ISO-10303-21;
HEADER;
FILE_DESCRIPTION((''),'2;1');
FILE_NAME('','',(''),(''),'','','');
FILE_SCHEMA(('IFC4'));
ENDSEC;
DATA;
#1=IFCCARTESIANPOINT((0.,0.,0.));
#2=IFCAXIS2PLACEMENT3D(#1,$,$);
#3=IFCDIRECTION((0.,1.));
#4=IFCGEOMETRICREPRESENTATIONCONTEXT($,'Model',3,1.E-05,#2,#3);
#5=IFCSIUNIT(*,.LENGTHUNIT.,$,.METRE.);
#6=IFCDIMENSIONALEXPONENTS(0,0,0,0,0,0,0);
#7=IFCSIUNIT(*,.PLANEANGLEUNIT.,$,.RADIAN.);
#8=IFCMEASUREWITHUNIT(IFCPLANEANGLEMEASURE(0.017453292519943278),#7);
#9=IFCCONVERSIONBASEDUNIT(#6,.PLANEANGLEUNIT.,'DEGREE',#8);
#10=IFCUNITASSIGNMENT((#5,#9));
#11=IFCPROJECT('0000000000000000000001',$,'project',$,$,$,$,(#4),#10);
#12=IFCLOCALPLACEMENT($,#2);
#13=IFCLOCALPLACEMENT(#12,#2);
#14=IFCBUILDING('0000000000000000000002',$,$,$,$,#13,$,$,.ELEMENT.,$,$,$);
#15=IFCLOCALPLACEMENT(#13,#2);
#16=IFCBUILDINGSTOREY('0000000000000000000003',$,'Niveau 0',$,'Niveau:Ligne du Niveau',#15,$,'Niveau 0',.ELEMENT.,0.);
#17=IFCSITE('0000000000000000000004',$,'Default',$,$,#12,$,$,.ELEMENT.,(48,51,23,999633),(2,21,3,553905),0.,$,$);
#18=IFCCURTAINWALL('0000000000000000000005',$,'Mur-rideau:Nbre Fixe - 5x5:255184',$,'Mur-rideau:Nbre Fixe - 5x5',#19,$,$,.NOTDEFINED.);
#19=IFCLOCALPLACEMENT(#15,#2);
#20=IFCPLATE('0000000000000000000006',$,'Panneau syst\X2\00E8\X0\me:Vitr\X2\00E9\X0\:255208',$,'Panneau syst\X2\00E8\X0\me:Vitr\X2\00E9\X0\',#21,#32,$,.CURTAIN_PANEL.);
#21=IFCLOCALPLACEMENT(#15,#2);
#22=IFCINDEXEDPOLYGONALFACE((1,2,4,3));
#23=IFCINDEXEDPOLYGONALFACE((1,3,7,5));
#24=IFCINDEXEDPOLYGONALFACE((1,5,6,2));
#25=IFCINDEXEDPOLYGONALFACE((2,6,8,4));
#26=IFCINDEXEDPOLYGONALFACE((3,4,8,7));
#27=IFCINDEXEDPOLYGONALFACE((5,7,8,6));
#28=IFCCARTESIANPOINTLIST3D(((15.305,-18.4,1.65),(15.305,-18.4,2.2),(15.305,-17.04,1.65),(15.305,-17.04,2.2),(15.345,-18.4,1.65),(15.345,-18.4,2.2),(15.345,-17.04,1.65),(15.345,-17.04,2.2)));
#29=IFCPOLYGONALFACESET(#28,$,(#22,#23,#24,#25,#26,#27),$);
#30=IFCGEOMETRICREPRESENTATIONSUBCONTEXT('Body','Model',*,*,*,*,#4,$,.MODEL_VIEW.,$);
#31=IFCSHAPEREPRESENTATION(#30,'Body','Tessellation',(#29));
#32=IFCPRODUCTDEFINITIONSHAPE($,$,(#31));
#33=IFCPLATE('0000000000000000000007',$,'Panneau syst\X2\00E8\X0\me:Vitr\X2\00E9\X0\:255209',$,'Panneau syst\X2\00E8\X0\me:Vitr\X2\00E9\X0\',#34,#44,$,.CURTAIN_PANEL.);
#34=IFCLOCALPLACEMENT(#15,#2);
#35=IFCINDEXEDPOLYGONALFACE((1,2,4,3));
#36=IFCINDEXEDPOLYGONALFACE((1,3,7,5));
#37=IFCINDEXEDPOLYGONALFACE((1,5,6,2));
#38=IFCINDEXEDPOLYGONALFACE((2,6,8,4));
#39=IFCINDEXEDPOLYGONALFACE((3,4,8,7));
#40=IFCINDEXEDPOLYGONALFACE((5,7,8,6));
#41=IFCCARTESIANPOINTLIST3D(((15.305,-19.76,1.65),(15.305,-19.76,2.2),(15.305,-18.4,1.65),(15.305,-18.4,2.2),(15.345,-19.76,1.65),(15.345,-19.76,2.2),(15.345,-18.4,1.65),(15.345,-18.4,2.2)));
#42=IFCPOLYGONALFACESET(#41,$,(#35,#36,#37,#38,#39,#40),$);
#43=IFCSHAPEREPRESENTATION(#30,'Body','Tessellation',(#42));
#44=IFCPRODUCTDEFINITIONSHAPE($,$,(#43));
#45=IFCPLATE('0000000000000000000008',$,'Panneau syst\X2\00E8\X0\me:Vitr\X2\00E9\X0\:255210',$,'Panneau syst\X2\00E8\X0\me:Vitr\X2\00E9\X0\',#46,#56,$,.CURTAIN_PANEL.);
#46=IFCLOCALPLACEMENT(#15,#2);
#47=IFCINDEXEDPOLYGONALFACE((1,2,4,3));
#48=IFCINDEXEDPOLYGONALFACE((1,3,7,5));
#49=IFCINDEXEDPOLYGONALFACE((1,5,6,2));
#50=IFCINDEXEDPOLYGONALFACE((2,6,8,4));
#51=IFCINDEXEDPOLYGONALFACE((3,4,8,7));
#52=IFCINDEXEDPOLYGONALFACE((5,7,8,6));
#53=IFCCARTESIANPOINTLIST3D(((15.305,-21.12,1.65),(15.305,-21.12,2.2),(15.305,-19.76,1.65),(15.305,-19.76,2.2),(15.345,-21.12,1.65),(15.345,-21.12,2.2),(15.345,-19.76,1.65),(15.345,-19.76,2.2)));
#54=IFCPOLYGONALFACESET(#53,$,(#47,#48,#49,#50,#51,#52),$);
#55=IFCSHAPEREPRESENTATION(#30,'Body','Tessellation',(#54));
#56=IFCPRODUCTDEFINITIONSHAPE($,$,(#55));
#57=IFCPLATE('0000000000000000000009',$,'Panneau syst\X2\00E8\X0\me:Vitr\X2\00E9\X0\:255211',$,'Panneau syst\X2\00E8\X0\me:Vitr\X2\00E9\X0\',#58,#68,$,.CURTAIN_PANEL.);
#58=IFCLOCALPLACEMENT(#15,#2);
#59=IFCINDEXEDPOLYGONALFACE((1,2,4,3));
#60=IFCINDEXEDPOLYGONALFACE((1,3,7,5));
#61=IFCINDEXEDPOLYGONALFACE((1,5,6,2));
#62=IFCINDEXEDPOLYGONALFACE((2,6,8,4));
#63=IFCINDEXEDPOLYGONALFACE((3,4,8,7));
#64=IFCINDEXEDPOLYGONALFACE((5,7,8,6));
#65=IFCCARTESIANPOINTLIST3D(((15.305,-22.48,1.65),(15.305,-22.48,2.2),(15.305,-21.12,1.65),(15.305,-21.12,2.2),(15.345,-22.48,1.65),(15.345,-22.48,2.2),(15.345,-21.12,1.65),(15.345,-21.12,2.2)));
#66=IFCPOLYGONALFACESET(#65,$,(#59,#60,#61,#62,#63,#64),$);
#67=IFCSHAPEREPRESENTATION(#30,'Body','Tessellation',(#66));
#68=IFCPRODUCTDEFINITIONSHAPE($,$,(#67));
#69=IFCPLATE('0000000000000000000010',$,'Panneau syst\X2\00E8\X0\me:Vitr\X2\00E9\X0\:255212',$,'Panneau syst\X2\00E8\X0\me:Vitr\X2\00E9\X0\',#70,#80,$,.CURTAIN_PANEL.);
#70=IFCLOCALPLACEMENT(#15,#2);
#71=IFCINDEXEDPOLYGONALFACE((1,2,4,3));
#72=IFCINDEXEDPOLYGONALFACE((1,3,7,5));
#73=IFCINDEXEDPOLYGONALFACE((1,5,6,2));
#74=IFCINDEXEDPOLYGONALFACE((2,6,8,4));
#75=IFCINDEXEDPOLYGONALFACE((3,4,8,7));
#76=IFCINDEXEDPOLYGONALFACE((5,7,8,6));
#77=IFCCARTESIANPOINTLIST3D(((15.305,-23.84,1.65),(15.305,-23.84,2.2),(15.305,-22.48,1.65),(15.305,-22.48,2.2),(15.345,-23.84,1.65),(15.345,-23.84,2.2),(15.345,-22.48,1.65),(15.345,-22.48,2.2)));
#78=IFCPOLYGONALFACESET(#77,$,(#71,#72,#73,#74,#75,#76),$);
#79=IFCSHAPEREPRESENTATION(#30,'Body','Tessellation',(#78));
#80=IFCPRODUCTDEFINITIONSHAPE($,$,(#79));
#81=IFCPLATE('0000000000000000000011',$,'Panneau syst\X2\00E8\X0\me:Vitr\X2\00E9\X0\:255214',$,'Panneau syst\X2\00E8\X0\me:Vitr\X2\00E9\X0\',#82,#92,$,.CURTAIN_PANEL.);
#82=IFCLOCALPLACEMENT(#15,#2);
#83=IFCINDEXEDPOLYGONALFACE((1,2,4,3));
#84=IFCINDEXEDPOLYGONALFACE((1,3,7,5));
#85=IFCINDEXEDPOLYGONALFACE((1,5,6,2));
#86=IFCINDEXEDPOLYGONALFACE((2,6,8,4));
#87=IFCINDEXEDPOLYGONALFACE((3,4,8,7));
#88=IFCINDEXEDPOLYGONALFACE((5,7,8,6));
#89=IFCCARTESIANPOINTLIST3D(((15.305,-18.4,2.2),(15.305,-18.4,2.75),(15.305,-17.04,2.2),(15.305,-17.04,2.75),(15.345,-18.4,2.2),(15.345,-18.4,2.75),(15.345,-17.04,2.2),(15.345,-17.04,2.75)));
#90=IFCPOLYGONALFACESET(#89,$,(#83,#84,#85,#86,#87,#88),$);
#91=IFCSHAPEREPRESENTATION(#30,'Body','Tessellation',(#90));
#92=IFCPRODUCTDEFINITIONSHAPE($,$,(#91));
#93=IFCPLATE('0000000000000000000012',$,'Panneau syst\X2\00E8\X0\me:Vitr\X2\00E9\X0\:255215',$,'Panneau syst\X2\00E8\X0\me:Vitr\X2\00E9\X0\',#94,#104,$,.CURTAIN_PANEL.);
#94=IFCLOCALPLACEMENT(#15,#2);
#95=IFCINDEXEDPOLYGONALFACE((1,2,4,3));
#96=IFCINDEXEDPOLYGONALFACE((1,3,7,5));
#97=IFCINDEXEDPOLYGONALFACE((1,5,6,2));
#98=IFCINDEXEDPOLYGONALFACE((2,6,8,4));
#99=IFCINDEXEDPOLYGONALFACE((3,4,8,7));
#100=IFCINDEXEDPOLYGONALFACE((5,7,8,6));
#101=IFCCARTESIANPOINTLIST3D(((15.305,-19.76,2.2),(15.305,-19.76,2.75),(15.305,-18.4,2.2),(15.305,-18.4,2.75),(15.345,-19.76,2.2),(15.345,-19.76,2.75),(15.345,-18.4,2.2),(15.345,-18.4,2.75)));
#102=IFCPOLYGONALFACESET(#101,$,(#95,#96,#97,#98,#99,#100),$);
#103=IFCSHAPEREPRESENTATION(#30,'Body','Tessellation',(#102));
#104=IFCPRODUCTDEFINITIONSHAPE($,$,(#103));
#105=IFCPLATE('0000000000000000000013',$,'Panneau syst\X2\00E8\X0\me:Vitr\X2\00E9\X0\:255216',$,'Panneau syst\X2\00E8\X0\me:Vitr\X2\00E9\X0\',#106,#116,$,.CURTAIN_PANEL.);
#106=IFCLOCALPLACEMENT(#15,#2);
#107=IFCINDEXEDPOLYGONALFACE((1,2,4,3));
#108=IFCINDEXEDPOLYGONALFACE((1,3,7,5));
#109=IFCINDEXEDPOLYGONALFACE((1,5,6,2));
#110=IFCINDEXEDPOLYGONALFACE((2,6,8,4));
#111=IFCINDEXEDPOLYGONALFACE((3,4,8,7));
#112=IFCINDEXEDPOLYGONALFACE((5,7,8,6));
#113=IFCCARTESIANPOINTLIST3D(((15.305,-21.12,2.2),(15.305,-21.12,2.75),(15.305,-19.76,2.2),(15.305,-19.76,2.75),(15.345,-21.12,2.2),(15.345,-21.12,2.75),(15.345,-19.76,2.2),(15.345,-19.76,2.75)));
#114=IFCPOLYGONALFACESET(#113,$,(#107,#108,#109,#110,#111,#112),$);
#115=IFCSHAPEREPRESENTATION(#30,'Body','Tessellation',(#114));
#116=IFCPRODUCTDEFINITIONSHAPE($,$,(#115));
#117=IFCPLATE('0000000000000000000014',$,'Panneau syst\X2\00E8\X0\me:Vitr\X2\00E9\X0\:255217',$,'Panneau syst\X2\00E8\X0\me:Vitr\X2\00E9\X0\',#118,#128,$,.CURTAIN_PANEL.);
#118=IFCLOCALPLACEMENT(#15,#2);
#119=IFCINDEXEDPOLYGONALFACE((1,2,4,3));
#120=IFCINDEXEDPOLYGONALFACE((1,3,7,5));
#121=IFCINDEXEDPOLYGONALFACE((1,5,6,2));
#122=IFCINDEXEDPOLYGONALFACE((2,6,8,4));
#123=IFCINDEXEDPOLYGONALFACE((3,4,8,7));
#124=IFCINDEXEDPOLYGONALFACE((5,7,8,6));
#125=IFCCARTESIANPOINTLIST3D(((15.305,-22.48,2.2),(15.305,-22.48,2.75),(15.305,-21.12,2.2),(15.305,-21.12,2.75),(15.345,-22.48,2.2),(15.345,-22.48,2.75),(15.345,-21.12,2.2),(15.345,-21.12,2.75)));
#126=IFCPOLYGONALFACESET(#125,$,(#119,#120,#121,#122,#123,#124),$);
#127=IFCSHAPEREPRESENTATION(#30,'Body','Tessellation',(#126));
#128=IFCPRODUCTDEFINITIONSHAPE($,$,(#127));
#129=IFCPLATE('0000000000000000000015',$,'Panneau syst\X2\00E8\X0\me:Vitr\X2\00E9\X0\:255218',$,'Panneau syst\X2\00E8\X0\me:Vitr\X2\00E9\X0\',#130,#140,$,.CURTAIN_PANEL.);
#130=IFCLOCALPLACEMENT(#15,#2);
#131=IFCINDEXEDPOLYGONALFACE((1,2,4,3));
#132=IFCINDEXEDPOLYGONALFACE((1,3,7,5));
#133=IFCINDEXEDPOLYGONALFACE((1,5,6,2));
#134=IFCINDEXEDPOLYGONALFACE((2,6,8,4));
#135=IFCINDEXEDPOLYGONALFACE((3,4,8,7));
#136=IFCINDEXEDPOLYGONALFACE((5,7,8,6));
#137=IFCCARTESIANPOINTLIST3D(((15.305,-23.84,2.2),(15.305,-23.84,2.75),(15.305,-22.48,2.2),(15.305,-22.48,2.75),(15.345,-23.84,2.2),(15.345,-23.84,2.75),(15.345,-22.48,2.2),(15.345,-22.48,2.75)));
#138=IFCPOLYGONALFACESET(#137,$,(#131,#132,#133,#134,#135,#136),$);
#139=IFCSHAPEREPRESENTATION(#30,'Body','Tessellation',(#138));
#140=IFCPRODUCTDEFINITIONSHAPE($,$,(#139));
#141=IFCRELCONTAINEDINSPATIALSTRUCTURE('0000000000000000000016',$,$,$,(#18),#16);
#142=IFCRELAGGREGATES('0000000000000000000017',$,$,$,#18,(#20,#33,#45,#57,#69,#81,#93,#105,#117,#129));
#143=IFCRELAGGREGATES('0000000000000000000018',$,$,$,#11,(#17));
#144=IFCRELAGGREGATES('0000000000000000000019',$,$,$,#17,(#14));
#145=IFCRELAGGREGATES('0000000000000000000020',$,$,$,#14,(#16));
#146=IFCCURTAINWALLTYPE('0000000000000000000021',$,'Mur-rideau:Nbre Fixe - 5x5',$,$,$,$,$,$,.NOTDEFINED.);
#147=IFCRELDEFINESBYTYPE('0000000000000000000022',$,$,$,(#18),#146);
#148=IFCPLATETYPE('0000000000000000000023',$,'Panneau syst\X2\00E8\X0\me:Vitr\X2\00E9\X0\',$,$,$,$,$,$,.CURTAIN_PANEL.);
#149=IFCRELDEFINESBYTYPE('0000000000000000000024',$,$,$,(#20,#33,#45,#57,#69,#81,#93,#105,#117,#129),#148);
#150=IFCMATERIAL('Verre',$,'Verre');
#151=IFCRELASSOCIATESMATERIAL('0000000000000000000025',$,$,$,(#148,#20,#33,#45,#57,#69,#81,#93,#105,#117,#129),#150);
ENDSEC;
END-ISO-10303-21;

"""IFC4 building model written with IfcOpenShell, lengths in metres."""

from ifc_helpers import new_model, entity, si_unit, converted_unit, direction, frame, origin, place, context, subcontext, project, spatial, indexed_curve, outline, extrude, source, transform, mapped, material, type_object, type_shapes, element, aggregate, save


model = new_model("IFC4")

# Units and contexts
model_context = context("Model", 3, precision=1e-05, world=origin(), true_north=direction((0.0, 1.0)))
body_context = subcontext(model_context, "Body", "Model", "MODEL_VIEW")
ifc_project = project(units=[si_unit("LENGTHUNIT", "METRE"), converted_unit("PLANEANGLEUNIT", "DEGREE", entity("IfcPlaneAngleMeasure", 0.017453292519943278), si_unit("PLANEANGLEUNIT", "RADIAN"), dimensions=[0, 0, 0, 0, 0, 0, 0])], contexts=[model_context])

# Site, building, storey
site_placement = place(None, origin())
site = spatial("IfcSite", under=ifc_project, at=site_placement, Name="Default", CompositionType="ELEMENT", RefLatitude=(48, 51, 23, 999633), RefLongitude=(2, 21, 3, 553905), RefElevation=0.0)
building_placement = place(site_placement, origin())
building = spatial("IfcBuilding", under=site, at=building_placement, CompositionType="ELEMENT")
storey_placement = place(building_placement, origin())
storey = spatial("IfcBuildingStorey", under=building, at=storey_placement, Name="Niveau 0", ObjectType="Niveau:Ligne du Niveau", LongName="Niveau 0", CompositionType="ELEMENT", Elevation=0.0)

# Curtain wall, plates
curtain_wall_type = type_object("IfcCurtainWallType", Name="Mur-rideau:Nbre Fixe - 5x5", PredefinedType="NOTDEFINED")
curtain_wall_placement = place(storey_placement, origin())
curtain_wall = element("IfcCurtainWall", 1, at=curtain_wall_placement, inside=storey, type_object=curtain_wall_type, Name="Mur-rideau:Nbre Fixe - 5x5:255184", ObjectType="Mur-rideau:Nbre Fixe - 5x5", PredefinedType="NOTDEFINED")
ifc_material = material(Name="Verre", Category="Verre")
plate_type = type_object("IfcPlateType", Name="Panneau système:Vitré", PredefinedType="CURTAIN_PANEL", material=ifc_material)
shared_shape = source(origin(), body_context, "Body", "SweptSolid", [
    extrude(outline(indexed_curve([(-0.02, -0.68), (0.02, -0.68), (0.02, 0.68), (-0.02, 0.68), (-0.02, -0.68)], self_intersect=False)), frame((0.68, 0.02, 0.0), z_axis=(0.0, 0.0, 1.0), x_axis=(0.0, 1.0, 0.0)), (0.0, 0.0, 1.0), 0.55),
])
type_shapes(plate_type, [shared_shape])
plate_1_placement = place(curtain_wall_placement, frame((15.305, -17.04, 1.65), z_axis=(0.0, 0.0, 1.0), x_axis=(0.0, -1.0, 0.0)))
plate_1 = element("IfcPlate", 2, at=plate_1_placement, type_object=plate_type, material=ifc_material, Name="Panneau système:Vitré:255208", ObjectType="Panneau système:Vitré", PredefinedType="CURTAIN_PANEL", context=body_context, shape_type="MappedRepresentation", body=[
    mapped(shared_shape, transform((0.0, 0.0, 0.0), scale=1.0)),
])
plate_2_placement = place(curtain_wall_placement, frame((15.305, -18.4, 1.65), z_axis=(0.0, 0.0, 1.0), x_axis=(0.0, -1.0, 0.0)))
plate_2 = element("IfcPlate", 3, at=plate_2_placement, type_object=plate_type, material=ifc_material, Name="Panneau système:Vitré:255209", ObjectType="Panneau système:Vitré", PredefinedType="CURTAIN_PANEL", context=body_context, shape_type="MappedRepresentation", body=[
    mapped(shared_shape, transform((0.0, 0.0, 0.0), scale=1.0)),
])
plate_3_placement = place(curtain_wall_placement, frame((15.305, -19.76, 1.65), z_axis=(0.0, 0.0, 1.0), x_axis=(0.0, -1.0, 0.0)))
plate_3 = element("IfcPlate", 4, at=plate_3_placement, type_object=plate_type, material=ifc_material, Name="Panneau système:Vitré:255210", ObjectType="Panneau système:Vitré", PredefinedType="CURTAIN_PANEL", context=body_context, shape_type="MappedRepresentation", body=[
    mapped(shared_shape, transform((0.0, 0.0, 0.0), scale=1.0)),
])
plate_4_placement = place(curtain_wall_placement, frame((15.305, -21.12, 1.65), z_axis=(0.0, 0.0, 1.0), x_axis=(0.0, -1.0, 0.0)))
plate_4 = element("IfcPlate", 5, at=plate_4_placement, type_object=plate_type, material=ifc_material, Name="Panneau système:Vitré:255211", ObjectType="Panneau système:Vitré", PredefinedType="CURTAIN_PANEL", context=body_context, shape_type="MappedRepresentation", body=[
    mapped(shared_shape, transform((0.0, 0.0, 0.0), scale=1.0)),
])
plate_5_placement = place(curtain_wall_placement, frame((15.305, -22.48, 1.65), z_axis=(0.0, 0.0, 1.0), x_axis=(0.0, -1.0, 0.0)))
plate_5 = element("IfcPlate", 6, at=plate_5_placement, type_object=plate_type, material=ifc_material, Name="Panneau système:Vitré:255212", ObjectType="Panneau système:Vitré", PredefinedType="CURTAIN_PANEL", context=body_context, shape_type="MappedRepresentation", body=[
    mapped(shared_shape, transform((0.0, 0.0, 0.0), scale=1.0)),
])
plate_6_placement = place(curtain_wall_placement, frame((15.305, -17.04, 2.2), z_axis=(0.0, 0.0, 1.0), x_axis=(0.0, -1.0, 0.0)))
plate_6 = element("IfcPlate", 7, at=plate_6_placement, type_object=plate_type, material=ifc_material, Name="Panneau système:Vitré:255214", ObjectType="Panneau système:Vitré", PredefinedType="CURTAIN_PANEL", context=body_context, shape_type="MappedRepresentation", body=[
    mapped(shared_shape, transform((0.0, 0.0, 0.0), scale=1.0)),
])
plate_7_placement = place(curtain_wall_placement, frame((15.305, -18.4, 2.2), z_axis=(0.0, 0.0, 1.0), x_axis=(0.0, -1.0, 0.0)))
plate_7 = element("IfcPlate", 8, at=plate_7_placement, type_object=plate_type, material=ifc_material, Name="Panneau système:Vitré:255215", ObjectType="Panneau système:Vitré", PredefinedType="CURTAIN_PANEL", context=body_context, shape_type="MappedRepresentation", body=[
    mapped(shared_shape, transform((0.0, 0.0, 0.0), scale=1.0)),
])
plate_8_placement = place(curtain_wall_placement, frame((15.305, -19.76, 2.2), z_axis=(0.0, 0.0, 1.0), x_axis=(0.0, -1.0, 0.0)))
plate_8 = element("IfcPlate", 9, at=plate_8_placement, type_object=plate_type, material=ifc_material, Name="Panneau système:Vitré:255216", ObjectType="Panneau système:Vitré", PredefinedType="CURTAIN_PANEL", context=body_context, shape_type="MappedRepresentation", body=[
    mapped(shared_shape, transform((0.0, 0.0, 0.0), scale=1.0)),
])
plate_9_placement = place(curtain_wall_placement, frame((15.305, -21.12, 2.2), z_axis=(0.0, 0.0, 1.0), x_axis=(0.0, -1.0, 0.0)))
plate_9 = element("IfcPlate", 10, at=plate_9_placement, type_object=plate_type, material=ifc_material, Name="Panneau système:Vitré:255217", ObjectType="Panneau système:Vitré", PredefinedType="CURTAIN_PANEL", context=body_context, shape_type="MappedRepresentation", body=[
    mapped(shared_shape, transform((0.0, 0.0, 0.0), scale=1.0)),
])
plate_10_placement = place(curtain_wall_placement, frame((15.305, -22.48, 2.2), z_axis=(0.0, 0.0, 1.0), x_axis=(0.0, -1.0, 0.0)))
plate_10 = element("IfcPlate", 11, at=plate_10_placement, type_object=plate_type, material=ifc_material, Name="Panneau système:Vitré:255218", ObjectType="Panneau système:Vitré", PredefinedType="CURTAIN_PANEL", context=body_context, shape_type="MappedRepresentation", body=[
    mapped(shared_shape, transform((0.0, 0.0, 0.0), scale=1.0)),
])
aggregate(curtain_wall, [plate_1, plate_2, plate_3, plate_4, plate_5, plate_6, plate_7, plate_8, plate_9, plate_10])

save(model, "model.ifc")
